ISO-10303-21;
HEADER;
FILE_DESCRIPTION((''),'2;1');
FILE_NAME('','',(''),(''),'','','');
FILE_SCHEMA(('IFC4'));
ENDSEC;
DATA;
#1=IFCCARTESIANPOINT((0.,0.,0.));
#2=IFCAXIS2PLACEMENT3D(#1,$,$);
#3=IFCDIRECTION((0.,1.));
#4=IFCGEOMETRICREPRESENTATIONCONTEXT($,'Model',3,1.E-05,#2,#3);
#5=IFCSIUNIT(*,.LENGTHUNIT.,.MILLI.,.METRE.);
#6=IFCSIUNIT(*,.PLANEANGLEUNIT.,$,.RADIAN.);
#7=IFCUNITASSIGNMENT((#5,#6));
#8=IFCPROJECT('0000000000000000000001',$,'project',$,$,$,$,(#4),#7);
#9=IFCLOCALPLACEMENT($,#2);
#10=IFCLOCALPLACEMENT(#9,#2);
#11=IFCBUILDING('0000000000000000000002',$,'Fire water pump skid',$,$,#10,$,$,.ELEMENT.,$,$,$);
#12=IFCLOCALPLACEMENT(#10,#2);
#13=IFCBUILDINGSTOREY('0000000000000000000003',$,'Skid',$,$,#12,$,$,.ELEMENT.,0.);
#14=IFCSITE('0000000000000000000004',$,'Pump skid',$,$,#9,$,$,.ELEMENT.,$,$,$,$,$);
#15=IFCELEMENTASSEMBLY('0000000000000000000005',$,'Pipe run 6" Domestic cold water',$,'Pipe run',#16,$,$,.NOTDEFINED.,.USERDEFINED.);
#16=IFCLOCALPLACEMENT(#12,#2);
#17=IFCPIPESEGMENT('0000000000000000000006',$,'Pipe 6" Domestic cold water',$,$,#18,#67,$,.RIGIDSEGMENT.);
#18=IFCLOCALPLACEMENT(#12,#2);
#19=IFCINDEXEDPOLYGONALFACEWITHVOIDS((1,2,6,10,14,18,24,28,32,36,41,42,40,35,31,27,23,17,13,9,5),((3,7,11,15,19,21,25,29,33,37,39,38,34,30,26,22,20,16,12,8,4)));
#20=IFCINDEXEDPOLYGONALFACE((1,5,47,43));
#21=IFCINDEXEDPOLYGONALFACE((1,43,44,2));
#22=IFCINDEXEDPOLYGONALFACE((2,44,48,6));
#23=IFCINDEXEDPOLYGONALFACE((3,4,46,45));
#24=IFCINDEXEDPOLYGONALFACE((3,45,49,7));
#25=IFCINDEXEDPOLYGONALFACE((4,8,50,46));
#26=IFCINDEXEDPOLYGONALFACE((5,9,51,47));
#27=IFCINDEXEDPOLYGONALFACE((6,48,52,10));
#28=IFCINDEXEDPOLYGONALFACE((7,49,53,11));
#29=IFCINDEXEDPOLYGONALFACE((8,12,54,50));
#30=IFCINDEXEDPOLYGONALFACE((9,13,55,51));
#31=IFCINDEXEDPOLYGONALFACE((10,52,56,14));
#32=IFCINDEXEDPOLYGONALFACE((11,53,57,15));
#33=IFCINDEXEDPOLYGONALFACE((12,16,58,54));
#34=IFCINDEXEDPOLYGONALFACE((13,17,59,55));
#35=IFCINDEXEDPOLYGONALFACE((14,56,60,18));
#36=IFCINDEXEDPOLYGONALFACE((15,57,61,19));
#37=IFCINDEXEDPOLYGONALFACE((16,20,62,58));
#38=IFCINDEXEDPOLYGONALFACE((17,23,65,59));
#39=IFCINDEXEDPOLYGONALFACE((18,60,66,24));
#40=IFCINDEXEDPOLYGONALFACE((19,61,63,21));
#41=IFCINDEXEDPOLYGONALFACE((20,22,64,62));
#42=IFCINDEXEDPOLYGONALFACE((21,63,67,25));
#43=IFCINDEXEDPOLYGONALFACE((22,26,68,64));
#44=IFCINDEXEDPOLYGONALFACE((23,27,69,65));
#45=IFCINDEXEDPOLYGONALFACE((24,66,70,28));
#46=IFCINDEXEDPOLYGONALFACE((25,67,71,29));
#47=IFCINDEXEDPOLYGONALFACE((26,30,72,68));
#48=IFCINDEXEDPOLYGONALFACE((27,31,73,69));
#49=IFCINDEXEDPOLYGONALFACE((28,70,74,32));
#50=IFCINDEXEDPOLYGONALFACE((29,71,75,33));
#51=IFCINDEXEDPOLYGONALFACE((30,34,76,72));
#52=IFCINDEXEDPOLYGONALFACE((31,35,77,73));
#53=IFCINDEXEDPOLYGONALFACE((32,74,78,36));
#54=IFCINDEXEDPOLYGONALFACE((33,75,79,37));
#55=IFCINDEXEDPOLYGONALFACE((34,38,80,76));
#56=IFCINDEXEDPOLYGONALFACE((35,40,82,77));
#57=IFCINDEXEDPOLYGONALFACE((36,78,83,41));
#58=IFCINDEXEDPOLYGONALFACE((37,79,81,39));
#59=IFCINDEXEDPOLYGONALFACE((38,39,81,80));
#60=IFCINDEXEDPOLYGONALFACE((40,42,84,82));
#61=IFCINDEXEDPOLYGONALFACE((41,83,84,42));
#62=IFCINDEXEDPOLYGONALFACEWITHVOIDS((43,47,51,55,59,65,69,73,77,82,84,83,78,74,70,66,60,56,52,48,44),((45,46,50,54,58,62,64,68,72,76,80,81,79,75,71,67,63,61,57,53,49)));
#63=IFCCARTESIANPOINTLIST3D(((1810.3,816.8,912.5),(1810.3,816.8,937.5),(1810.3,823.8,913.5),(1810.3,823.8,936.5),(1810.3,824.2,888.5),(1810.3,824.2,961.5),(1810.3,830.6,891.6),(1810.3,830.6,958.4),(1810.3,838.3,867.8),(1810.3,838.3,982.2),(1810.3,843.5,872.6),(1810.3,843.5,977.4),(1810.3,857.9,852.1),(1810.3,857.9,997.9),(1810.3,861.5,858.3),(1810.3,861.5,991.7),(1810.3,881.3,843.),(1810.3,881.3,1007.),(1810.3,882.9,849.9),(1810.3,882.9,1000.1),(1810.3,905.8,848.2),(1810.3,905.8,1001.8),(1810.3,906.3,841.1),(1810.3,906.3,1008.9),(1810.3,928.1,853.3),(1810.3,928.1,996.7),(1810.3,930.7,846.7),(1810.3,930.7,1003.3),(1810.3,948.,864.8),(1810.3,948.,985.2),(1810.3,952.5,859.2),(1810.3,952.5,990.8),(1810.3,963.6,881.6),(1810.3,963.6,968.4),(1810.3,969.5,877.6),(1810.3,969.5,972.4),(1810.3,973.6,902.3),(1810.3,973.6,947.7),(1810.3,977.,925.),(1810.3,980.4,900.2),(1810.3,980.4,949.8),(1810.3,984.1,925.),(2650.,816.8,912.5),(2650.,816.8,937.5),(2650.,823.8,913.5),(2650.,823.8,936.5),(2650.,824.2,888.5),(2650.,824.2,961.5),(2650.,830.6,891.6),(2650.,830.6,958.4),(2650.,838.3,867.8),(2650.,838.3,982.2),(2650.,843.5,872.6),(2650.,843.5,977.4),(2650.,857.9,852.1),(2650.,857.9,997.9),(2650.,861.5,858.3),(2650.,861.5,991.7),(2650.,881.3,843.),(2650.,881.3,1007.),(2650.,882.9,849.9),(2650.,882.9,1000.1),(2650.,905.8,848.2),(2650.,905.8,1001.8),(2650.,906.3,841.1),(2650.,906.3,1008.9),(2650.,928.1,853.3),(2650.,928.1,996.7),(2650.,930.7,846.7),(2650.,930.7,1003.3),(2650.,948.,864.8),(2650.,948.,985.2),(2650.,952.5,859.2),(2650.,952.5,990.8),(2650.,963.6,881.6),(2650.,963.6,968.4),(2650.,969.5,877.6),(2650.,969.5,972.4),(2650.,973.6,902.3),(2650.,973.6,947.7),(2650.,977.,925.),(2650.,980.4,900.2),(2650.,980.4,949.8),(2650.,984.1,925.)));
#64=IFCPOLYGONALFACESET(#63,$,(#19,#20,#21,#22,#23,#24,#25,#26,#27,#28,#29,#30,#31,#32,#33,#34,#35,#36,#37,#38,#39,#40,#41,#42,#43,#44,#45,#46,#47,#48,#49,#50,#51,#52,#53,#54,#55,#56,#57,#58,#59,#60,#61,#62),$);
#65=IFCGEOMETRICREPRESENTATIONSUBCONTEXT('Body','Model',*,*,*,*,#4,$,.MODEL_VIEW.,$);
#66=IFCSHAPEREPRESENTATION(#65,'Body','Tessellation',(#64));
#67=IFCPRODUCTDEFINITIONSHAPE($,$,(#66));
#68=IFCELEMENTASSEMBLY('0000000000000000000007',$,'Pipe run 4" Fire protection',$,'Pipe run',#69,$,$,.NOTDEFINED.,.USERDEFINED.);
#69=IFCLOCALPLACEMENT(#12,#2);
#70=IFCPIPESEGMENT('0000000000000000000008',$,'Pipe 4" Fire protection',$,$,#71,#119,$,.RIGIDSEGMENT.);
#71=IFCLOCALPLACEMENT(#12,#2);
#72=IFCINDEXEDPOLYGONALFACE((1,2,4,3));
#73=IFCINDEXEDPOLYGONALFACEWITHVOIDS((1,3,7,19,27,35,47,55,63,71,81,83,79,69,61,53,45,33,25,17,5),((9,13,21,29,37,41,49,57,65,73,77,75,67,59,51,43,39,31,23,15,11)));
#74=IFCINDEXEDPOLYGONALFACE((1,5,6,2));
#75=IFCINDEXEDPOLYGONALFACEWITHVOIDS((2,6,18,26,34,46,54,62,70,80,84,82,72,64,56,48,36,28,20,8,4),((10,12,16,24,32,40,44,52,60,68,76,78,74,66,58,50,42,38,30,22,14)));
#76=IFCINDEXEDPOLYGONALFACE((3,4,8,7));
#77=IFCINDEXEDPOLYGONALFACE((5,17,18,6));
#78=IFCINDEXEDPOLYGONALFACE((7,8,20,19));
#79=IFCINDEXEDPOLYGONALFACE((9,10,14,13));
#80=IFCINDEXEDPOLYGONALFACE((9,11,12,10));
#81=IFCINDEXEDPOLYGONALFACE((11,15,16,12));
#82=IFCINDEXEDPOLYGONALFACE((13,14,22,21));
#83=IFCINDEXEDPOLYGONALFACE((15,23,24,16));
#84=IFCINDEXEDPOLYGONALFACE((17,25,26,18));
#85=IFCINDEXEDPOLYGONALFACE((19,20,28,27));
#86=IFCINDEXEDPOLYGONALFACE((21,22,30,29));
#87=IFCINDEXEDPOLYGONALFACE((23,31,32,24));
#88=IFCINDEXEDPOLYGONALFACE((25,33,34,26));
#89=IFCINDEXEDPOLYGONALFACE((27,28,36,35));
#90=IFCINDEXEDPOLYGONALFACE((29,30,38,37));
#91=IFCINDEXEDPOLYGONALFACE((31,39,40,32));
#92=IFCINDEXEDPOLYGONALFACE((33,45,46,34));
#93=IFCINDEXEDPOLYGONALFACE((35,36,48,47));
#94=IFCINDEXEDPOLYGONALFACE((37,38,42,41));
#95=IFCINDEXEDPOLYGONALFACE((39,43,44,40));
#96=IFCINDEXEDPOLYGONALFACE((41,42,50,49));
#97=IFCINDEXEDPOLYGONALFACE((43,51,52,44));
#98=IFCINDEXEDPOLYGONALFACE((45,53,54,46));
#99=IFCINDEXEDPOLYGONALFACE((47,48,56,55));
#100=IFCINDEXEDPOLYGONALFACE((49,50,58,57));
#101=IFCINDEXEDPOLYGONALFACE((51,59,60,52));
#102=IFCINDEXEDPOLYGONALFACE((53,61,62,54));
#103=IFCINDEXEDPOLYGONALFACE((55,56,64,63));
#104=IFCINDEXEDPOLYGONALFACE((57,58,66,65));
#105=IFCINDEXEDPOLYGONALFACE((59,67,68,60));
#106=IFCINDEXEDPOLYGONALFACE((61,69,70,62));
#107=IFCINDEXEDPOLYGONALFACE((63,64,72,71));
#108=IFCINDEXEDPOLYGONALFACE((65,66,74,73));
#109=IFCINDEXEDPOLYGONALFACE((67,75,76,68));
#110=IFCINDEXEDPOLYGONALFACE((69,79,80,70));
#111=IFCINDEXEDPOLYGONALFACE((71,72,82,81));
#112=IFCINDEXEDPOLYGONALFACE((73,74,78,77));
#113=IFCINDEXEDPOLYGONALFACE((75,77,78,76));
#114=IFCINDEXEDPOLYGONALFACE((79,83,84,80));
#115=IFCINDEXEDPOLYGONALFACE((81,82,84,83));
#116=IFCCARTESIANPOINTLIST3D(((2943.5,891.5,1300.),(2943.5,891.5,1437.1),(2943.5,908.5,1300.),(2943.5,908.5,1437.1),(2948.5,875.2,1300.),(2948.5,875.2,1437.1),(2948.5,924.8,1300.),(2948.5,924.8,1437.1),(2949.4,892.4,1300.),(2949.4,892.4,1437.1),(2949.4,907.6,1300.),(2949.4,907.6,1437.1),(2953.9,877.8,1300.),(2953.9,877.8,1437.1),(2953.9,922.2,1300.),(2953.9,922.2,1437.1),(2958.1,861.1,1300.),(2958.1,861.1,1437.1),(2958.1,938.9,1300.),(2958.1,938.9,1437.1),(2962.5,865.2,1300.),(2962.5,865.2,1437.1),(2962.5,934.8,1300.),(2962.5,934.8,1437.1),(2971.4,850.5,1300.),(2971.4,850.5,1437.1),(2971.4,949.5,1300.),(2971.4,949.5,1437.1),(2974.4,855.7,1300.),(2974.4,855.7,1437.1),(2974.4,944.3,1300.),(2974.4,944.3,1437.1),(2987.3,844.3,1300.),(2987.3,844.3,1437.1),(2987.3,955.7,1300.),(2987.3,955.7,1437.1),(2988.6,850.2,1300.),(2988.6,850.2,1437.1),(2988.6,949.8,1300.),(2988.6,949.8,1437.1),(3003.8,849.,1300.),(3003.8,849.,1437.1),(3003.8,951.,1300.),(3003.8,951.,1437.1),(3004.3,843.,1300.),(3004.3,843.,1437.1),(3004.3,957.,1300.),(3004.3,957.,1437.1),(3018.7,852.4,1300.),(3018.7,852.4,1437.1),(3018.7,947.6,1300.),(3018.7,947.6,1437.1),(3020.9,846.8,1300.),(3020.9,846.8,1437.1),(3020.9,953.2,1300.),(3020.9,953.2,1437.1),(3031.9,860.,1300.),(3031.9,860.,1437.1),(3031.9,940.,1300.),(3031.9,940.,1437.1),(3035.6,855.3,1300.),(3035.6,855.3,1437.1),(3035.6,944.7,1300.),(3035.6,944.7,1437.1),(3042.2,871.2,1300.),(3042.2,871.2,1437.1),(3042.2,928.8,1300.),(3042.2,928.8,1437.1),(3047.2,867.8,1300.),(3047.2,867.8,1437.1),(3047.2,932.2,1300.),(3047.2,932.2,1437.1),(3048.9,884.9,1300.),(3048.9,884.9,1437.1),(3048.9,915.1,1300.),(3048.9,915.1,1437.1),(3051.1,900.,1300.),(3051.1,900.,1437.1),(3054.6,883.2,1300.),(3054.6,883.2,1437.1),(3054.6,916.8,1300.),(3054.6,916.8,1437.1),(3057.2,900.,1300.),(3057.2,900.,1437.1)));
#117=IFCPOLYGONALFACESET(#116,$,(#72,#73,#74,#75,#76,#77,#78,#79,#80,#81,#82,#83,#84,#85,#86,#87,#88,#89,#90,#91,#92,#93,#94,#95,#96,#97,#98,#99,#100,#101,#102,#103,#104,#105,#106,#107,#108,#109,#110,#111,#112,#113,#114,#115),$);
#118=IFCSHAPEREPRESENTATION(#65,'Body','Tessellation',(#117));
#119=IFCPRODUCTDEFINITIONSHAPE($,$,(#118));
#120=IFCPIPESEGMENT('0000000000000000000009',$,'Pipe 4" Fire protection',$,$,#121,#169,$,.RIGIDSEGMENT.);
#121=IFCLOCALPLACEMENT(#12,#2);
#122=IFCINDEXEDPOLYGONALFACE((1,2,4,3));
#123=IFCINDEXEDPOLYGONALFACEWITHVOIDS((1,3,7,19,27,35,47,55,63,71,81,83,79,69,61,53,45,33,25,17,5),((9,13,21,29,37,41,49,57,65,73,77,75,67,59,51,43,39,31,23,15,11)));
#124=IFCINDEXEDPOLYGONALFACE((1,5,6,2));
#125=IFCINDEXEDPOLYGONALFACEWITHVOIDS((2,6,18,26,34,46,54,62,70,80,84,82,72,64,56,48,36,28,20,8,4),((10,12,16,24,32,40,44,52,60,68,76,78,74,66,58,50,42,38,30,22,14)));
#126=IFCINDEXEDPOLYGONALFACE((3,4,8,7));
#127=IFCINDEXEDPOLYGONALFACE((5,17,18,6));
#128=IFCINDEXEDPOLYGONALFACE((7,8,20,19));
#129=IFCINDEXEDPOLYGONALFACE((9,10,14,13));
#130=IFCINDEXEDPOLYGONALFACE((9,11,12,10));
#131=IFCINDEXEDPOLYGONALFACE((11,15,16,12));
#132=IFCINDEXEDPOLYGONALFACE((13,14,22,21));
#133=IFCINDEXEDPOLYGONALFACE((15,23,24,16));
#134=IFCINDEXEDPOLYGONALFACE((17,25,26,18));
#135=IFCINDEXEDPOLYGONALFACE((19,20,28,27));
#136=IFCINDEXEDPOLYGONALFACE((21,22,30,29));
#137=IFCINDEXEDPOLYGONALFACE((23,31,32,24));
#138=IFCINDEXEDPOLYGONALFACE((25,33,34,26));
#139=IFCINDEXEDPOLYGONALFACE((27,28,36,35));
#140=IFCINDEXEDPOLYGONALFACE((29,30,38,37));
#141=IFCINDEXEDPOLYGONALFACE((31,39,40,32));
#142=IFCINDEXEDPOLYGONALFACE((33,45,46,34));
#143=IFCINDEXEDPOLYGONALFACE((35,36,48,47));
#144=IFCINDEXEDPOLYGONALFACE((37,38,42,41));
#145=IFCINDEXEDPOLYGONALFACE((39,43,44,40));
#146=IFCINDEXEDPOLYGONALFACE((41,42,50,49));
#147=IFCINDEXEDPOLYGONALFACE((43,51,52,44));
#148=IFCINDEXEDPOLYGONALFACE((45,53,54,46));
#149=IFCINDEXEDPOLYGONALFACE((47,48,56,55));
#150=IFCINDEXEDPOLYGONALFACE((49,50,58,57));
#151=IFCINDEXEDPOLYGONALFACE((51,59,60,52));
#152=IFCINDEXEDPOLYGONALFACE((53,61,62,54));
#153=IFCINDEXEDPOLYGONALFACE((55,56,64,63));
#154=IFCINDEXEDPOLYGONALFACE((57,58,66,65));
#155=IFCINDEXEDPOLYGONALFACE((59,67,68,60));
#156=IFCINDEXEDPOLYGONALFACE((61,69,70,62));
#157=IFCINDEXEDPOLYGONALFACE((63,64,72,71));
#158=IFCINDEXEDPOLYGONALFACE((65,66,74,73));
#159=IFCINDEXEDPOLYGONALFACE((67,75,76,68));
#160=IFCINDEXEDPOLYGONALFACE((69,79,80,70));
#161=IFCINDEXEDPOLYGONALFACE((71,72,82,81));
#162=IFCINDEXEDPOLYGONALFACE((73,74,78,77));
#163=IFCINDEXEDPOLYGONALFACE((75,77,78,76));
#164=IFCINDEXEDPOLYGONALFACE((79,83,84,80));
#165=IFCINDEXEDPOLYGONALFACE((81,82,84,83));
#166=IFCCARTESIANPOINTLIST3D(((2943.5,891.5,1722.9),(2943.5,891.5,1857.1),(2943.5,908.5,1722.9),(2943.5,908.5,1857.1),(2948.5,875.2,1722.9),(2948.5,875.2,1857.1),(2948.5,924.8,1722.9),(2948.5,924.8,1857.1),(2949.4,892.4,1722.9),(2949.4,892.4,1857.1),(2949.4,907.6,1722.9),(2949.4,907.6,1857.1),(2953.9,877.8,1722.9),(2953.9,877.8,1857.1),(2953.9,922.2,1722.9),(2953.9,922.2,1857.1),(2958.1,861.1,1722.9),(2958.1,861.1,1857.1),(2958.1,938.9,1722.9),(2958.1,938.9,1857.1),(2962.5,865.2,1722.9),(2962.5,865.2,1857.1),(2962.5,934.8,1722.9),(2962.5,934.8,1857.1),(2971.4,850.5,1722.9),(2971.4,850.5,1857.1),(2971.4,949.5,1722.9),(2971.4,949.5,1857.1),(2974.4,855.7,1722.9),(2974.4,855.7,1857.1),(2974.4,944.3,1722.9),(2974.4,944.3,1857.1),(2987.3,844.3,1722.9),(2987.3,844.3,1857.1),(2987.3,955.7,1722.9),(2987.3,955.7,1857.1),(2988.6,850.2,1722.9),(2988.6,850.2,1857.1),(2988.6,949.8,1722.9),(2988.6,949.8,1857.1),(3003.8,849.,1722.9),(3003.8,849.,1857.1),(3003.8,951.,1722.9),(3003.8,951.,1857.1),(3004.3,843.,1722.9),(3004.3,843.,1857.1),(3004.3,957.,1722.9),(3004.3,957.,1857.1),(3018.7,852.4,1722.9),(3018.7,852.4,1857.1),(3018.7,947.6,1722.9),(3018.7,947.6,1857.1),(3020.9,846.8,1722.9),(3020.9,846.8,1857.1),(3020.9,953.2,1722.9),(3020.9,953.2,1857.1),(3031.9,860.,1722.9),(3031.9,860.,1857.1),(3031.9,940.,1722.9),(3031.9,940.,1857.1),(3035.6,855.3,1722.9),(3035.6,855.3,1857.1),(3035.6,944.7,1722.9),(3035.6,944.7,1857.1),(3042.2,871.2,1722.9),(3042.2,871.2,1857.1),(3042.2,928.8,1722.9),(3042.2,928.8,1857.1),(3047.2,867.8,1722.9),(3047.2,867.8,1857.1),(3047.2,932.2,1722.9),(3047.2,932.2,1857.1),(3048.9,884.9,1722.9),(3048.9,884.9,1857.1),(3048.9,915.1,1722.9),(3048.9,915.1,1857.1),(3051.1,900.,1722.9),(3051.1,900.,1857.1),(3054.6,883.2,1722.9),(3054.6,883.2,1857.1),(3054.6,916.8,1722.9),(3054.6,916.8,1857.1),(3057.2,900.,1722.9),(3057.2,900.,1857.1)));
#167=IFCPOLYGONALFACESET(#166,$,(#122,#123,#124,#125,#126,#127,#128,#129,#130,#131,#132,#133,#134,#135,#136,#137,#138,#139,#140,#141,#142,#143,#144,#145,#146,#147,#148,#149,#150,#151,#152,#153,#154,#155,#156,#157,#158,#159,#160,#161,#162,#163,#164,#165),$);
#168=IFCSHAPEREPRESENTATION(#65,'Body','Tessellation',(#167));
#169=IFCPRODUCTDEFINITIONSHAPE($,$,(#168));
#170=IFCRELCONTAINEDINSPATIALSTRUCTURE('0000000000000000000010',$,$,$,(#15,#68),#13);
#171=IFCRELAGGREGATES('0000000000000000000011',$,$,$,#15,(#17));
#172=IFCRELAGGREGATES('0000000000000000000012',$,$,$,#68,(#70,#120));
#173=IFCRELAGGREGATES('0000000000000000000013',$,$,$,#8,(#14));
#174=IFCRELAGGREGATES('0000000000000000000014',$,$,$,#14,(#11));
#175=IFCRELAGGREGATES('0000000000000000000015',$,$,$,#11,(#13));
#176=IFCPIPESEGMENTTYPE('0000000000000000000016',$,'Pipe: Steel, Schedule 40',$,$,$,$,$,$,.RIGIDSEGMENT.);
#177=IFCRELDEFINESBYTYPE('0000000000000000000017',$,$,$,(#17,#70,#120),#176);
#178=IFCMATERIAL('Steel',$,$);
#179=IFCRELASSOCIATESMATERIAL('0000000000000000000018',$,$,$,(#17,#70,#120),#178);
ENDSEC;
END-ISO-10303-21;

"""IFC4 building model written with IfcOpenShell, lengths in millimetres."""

from ifc_helpers import new_model, si_unit, direction, frame, origin, origin_with_axes, origin_2d, place, context, subcontext, project, spatial, hollow_circle, extrude, material, type_object, element, aggregate, save


model = new_model("IFC4")

# Units and contexts
model_context = context("Model", 3, precision=1e-05, world=origin(), true_north=direction((0.0, 1.0)))
body_context = subcontext(model_context, "Body", "Model", "MODEL_VIEW")
ifc_project = project(units=[si_unit("LENGTHUNIT", "METRE", prefix="MILLI"), si_unit("PLANEANGLEUNIT", "RADIAN")], contexts=[model_context])

# Site, building, storey
site_placement = place(None, origin())
site = spatial("IfcSite", under=ifc_project, at=site_placement, Name="Pump skid", CompositionType="ELEMENT")
building_placement = place(site_placement, origin())
building = spatial("IfcBuilding", under=site, at=building_placement, Name="Fire water pump skid", CompositionType="ELEMENT")
storey_placement = place(building_placement, origin())
storey = spatial("IfcBuildingStorey", under=building, at=storey_placement, Name="Skid", CompositionType="ELEMENT", Elevation=0.0)

# Element assemblies, pipe segments
ifc_material = material(Name="Steel")
pipe_segment_type = type_object("IfcPipeSegmentType", Name="Pipe: Steel, Schedule 40", PredefinedType="RIGIDSEGMENT")
assembly_1_placement = place(storey_placement, origin_with_axes())
assembly_1 = element("IfcElementAssembly", 1, at=assembly_1_placement, inside=storey, Name="Pipe run 6\" Domestic cold water", ObjectType="Pipe run", AssemblyPlace="NOTDEFINED", PredefinedType="USERDEFINED")
pipe_segment_1_placement = place(storey_placement, origin_with_axes())
pipe_segment_1 = element("IfcPipeSegment", 2, at=pipe_segment_1_placement, type_object=pipe_segment_type, material=ifc_material, Name="Pipe 6\" Domestic cold water", PredefinedType="RIGIDSEGMENT", context=body_context, shape_type="SweptSolid", body=[
    extrude(hollow_circle(Radius=84.1, WallThickness=7.1, at=origin_2d()), frame((1810.3, 900.0, 925.0), z_axis=(1.0, 0.0, 0.0), x_axis=(0.0, 1.0, 0.0)), (0.0, 0.0, 1.0), 839.7),
])
assembly_2_placement = place(storey_placement, origin_with_axes())
assembly_2 = element("IfcElementAssembly", 3, at=assembly_2_placement, inside=storey, Name="Pipe run 4\" Fire protection", ObjectType="Pipe run", AssemblyPlace="NOTDEFINED", PredefinedType="USERDEFINED")
pipe_segment_2_placement = place(storey_placement, origin_with_axes())
pipe_segment_2 = element("IfcPipeSegment", 4, at=pipe_segment_2_placement, type_object=pipe_segment_type, material=ifc_material, Name="Pipe 4\" Fire protection", PredefinedType="RIGIDSEGMENT", context=body_context, shape_type="SweptSolid", body=[
    extrude(hollow_circle(Radius=57.1, WallThickness=6.0, at=origin_2d()), frame((3000.0, 900.0, 1300.0), z_axis=(0.0, 0.0, 1.0), x_axis=(1.0, 0.0, 0.0)), (0.0, 0.0, 1.0), 137.1),
])
pipe_segment_3_placement = place(storey_placement, origin_with_axes())
pipe_segment_3 = element("IfcPipeSegment", 5, at=pipe_segment_3_placement, type_object=pipe_segment_type, material=ifc_material, Name="Pipe 4\" Fire protection", PredefinedType="RIGIDSEGMENT", context=body_context, shape_type="SweptSolid", body=[
    extrude(hollow_circle(Radius=57.1, WallThickness=6.0, at=origin_2d()), frame((3000.0, 900.0, 1722.9), z_axis=(0.0, 0.0, 1.0), x_axis=(1.0, 0.0, 0.0)), (0.0, 0.0, 1.0), 134.2),
])

aggregate(assembly_1, [pipe_segment_1])

aggregate(assembly_2, [pipe_segment_2, pipe_segment_3])

save(model, "model.ifc")
